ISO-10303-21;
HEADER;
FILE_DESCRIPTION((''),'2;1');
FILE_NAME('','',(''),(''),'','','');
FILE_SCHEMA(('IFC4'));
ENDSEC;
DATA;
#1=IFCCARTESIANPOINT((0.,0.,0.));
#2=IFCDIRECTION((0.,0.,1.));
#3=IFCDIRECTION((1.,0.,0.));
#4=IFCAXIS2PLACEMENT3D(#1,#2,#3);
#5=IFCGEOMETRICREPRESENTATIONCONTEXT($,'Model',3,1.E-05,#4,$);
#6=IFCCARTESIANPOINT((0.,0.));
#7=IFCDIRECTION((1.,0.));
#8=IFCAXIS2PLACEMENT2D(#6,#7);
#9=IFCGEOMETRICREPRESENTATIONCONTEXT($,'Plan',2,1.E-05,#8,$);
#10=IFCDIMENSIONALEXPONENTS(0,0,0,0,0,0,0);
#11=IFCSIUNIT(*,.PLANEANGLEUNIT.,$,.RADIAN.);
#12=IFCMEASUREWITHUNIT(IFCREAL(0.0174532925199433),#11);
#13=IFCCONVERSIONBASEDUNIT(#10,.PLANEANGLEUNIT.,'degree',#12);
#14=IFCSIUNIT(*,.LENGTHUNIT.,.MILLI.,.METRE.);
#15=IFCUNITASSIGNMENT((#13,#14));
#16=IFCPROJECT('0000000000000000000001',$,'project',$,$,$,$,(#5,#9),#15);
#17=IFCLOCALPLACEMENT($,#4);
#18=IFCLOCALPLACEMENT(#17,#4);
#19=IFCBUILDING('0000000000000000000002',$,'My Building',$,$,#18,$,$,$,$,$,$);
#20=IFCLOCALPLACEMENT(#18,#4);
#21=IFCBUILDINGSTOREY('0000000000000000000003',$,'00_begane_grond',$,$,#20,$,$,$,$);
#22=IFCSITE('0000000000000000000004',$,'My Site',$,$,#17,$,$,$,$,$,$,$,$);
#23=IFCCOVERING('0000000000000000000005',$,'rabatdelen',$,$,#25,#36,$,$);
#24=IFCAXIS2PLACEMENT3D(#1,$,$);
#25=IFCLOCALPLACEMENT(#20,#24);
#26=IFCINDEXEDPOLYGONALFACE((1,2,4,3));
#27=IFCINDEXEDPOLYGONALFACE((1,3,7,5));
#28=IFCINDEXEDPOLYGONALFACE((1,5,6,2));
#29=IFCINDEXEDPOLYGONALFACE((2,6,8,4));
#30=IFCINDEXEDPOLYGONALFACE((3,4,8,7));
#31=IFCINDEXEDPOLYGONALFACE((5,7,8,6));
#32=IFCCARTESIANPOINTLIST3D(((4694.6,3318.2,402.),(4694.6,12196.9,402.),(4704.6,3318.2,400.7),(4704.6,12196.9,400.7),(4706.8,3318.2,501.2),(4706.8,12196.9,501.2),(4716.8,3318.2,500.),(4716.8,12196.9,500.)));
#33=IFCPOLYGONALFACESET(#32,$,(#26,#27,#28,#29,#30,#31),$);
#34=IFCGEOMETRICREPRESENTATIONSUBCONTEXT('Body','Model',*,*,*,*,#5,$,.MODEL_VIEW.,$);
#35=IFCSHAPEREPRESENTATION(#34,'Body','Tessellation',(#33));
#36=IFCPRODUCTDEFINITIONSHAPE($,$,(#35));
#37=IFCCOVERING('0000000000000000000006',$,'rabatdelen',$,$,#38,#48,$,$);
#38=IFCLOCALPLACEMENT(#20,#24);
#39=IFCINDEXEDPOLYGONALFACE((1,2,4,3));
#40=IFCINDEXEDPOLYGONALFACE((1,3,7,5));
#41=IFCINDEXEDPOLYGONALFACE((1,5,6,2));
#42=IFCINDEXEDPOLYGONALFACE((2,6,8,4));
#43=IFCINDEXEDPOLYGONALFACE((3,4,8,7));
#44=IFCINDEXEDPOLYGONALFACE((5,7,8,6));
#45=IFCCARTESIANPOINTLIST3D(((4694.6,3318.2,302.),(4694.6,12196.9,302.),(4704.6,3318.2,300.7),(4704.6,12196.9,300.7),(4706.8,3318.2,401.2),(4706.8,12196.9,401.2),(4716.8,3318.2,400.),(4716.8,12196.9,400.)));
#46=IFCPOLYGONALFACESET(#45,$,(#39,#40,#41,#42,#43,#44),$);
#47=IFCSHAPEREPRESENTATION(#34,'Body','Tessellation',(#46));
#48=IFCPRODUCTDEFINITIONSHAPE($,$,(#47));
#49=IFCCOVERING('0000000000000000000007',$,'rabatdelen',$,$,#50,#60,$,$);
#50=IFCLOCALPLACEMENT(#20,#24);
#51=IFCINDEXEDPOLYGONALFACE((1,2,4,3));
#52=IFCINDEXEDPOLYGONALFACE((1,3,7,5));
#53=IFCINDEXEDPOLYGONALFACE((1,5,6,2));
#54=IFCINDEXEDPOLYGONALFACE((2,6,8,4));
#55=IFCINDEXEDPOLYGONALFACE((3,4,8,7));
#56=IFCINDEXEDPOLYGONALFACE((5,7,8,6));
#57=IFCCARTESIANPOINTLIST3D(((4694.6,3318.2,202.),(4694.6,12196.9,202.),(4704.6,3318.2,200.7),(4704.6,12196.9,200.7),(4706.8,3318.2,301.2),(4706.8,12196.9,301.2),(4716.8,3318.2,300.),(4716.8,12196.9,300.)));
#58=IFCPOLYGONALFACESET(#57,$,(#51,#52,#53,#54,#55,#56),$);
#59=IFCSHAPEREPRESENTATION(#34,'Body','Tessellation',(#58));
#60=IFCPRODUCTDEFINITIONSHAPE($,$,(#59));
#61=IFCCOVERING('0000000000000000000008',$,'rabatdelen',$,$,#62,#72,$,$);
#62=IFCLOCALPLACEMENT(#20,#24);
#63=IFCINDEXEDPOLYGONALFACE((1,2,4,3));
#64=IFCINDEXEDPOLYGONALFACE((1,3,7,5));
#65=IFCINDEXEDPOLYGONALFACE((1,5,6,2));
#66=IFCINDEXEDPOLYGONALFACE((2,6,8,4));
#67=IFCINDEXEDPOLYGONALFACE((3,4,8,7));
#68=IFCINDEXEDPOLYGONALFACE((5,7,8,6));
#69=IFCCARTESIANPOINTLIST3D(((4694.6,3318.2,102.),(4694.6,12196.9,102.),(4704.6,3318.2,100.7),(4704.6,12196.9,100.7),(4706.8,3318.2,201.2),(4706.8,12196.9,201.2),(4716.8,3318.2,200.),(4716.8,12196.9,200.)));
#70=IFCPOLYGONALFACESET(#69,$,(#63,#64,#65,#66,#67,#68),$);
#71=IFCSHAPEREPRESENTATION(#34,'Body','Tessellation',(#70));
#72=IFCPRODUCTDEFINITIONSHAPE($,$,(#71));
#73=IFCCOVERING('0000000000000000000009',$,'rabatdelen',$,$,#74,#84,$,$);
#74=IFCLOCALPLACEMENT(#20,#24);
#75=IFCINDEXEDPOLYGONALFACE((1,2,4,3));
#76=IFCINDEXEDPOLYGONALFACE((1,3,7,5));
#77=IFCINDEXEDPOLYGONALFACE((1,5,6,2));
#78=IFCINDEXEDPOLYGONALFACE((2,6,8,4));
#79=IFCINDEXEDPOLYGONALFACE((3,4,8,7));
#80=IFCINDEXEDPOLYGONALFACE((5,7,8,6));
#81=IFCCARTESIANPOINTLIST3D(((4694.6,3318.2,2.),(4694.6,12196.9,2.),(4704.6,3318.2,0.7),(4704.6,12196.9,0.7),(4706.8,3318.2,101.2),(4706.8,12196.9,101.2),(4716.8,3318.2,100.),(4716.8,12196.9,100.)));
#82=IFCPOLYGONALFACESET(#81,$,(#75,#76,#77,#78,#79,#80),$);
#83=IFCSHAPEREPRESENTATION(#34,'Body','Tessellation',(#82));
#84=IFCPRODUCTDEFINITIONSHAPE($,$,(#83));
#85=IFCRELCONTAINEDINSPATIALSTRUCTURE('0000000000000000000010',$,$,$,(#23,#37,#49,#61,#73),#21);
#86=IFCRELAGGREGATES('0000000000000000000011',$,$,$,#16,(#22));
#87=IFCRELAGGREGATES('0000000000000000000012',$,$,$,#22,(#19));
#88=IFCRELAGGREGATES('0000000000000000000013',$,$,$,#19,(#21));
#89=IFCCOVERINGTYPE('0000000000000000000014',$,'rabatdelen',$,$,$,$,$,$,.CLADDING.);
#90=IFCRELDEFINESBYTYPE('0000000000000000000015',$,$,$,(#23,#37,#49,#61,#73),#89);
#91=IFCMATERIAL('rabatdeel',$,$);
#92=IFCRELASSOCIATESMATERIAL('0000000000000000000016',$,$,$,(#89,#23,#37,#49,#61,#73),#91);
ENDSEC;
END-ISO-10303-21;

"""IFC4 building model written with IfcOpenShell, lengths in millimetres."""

from ifc_helpers import new_model, entity, si_unit, converted_unit, frame, origin_with_axes, origin_2d_with_axis, place, context, subcontext, project, spatial, rectangle, extrude, material, material_profile, profile_set, profile_usage, type_object, element, save


model = new_model("IFC4")

# Units and contexts
model_context = context("Model", 3, precision=1e-05, world=origin_with_axes())
plan_context = context("Plan", 2, precision=1e-05, world=origin_2d_with_axis())
body_context = subcontext(model_context, "Body", "Model", "MODEL_VIEW")
ifc_project = project(units=[converted_unit("PLANEANGLEUNIT", "degree", entity("IfcReal", 0.0174532925199433), si_unit("PLANEANGLEUNIT", "RADIAN"), dimensions=[0, 0, 0, 0, 0, 0, 0]), si_unit("LENGTHUNIT", "METRE", prefix="MILLI")], contexts=[model_context, plan_context])

# Site, building, storey
site_placement = place(None, origin_with_axes())
site = spatial("IfcSite", under=ifc_project, at=site_placement, Name="My Site")
building_placement = place(site_placement, origin_with_axes())
building = spatial("IfcBuilding", under=site, at=building_placement, Name="My Building")
storey_placement = place(building_placement, origin_with_axes())
storey = spatial("IfcBuildingStorey", under=building, at=storey_placement, Name="00_begane_grond")

# Coverings
ifc_material_1 = material(Name="rabatdeel")
ifc_material_profile = material_profile(ifc_material_1, rectangle(XDim=10.0, YDim=100.0))
ifc_profile_set = profile_set([ifc_material_profile])
covering_type = type_object("IfcCoveringType", Name="rabatdelen", PredefinedType="CLADDING", material=ifc_profile_set)
ifc_profile_usage_1 = profile_usage(ifc_profile_set, cardinal=7)
covering_1_placement = place(storey_placement, frame((4716.8, 12196.9, 500.0), z_axis=(0.0, -1.0, 0.0), x_axis=(0.992546, 0.0, -0.121869)))
element("IfcCovering", 1, at=covering_1_placement, inside=storey, type_object=covering_type, material=ifc_profile_usage_1, Name="rabatdelen", context=body_context, shape_type="SweptSolid", body=[
    extrude(rectangle(XDim=10.0, YDim=100.0), frame((-5.0, -50.0, 0.0), z_axis=(0.0, 0.0, 1.0), x_axis=(1.0, 0.0, 0.0)), (0.0, 0.0, 1.0), 8878.8),
])
ifc_profile_usage_2 = profile_usage(ifc_profile_set, cardinal=7)
covering_2_placement = place(storey_placement, frame((4716.8, 12196.9, 400.0), z_axis=(0.0, -1.0, 0.0), x_axis=(0.992546, 0.0, -0.121869)))
element("IfcCovering", 2, at=covering_2_placement, inside=storey, type_object=covering_type, material=ifc_profile_usage_2, Name="rabatdelen", context=body_context, shape_type="SweptSolid", body=[
    extrude(rectangle(XDim=10.0, YDim=100.0), frame((-5.0, -50.0, 0.0), z_axis=(0.0, 0.0, 1.0), x_axis=(1.0, 0.0, 0.0)), (0.0, 0.0, 1.0), 8878.8),
])
ifc_profile_usage_3 = profile_usage(ifc_profile_set, cardinal=7)
covering_3_placement = place(storey_placement, frame((4716.8, 12196.9, 300.0), z_axis=(0.0, -1.0, 0.0), x_axis=(0.992546, 0.0, -0.121869)))
element("IfcCovering", 3, at=covering_3_placement, inside=storey, type_object=covering_type, material=ifc_profile_usage_3, Name="rabatdelen", context=body_context, shape_type="SweptSolid", body=[
    extrude(rectangle(XDim=10.0, YDim=100.0), frame((-5.0, -50.0, 0.0), z_axis=(0.0, 0.0, 1.0), x_axis=(1.0, 0.0, 0.0)), (0.0, 0.0, 1.0), 8878.8),
])
ifc_profile_usage_4 = profile_usage(ifc_profile_set, cardinal=7)
covering_4_placement = place(storey_placement, frame((4716.8, 12196.9, 200.0), z_axis=(0.0, -1.0, 0.0), x_axis=(0.992546, 0.0, -0.121869)))
element("IfcCovering", 4, at=covering_4_placement, inside=storey, type_object=covering_type, material=ifc_profile_usage_4, Name="rabatdelen", context=body_context, shape_type="SweptSolid", body=[
    extrude(rectangle(XDim=10.0, YDim=100.0), frame((-5.0, -50.0, 0.0), z_axis=(0.0, 0.0, 1.0), x_axis=(1.0, 0.0, 0.0)), (0.0, 0.0, 1.0), 8878.8),
])
ifc_profile_usage_5 = profile_usage(ifc_profile_set, cardinal=7)
covering_5_placement = place(storey_placement, frame((4716.8, 12196.9, 100.0), z_axis=(0.0, -1.0, 0.0), x_axis=(0.992546, 0.0, -0.121869)))
element("IfcCovering", 5, at=covering_5_placement, inside=storey, type_object=covering_type, material=ifc_profile_usage_5, Name="rabatdelen", context=body_context, shape_type="SweptSolid", body=[
    extrude(rectangle(XDim=10.0, YDim=100.0), frame((-5.0, -50.0, 0.0), z_axis=(0.0, 0.0, 1.0), x_axis=(1.0, 0.0, 0.0)), (0.0, 0.0, 1.0), 8878.8),
])

save(model, "model.ifc")
